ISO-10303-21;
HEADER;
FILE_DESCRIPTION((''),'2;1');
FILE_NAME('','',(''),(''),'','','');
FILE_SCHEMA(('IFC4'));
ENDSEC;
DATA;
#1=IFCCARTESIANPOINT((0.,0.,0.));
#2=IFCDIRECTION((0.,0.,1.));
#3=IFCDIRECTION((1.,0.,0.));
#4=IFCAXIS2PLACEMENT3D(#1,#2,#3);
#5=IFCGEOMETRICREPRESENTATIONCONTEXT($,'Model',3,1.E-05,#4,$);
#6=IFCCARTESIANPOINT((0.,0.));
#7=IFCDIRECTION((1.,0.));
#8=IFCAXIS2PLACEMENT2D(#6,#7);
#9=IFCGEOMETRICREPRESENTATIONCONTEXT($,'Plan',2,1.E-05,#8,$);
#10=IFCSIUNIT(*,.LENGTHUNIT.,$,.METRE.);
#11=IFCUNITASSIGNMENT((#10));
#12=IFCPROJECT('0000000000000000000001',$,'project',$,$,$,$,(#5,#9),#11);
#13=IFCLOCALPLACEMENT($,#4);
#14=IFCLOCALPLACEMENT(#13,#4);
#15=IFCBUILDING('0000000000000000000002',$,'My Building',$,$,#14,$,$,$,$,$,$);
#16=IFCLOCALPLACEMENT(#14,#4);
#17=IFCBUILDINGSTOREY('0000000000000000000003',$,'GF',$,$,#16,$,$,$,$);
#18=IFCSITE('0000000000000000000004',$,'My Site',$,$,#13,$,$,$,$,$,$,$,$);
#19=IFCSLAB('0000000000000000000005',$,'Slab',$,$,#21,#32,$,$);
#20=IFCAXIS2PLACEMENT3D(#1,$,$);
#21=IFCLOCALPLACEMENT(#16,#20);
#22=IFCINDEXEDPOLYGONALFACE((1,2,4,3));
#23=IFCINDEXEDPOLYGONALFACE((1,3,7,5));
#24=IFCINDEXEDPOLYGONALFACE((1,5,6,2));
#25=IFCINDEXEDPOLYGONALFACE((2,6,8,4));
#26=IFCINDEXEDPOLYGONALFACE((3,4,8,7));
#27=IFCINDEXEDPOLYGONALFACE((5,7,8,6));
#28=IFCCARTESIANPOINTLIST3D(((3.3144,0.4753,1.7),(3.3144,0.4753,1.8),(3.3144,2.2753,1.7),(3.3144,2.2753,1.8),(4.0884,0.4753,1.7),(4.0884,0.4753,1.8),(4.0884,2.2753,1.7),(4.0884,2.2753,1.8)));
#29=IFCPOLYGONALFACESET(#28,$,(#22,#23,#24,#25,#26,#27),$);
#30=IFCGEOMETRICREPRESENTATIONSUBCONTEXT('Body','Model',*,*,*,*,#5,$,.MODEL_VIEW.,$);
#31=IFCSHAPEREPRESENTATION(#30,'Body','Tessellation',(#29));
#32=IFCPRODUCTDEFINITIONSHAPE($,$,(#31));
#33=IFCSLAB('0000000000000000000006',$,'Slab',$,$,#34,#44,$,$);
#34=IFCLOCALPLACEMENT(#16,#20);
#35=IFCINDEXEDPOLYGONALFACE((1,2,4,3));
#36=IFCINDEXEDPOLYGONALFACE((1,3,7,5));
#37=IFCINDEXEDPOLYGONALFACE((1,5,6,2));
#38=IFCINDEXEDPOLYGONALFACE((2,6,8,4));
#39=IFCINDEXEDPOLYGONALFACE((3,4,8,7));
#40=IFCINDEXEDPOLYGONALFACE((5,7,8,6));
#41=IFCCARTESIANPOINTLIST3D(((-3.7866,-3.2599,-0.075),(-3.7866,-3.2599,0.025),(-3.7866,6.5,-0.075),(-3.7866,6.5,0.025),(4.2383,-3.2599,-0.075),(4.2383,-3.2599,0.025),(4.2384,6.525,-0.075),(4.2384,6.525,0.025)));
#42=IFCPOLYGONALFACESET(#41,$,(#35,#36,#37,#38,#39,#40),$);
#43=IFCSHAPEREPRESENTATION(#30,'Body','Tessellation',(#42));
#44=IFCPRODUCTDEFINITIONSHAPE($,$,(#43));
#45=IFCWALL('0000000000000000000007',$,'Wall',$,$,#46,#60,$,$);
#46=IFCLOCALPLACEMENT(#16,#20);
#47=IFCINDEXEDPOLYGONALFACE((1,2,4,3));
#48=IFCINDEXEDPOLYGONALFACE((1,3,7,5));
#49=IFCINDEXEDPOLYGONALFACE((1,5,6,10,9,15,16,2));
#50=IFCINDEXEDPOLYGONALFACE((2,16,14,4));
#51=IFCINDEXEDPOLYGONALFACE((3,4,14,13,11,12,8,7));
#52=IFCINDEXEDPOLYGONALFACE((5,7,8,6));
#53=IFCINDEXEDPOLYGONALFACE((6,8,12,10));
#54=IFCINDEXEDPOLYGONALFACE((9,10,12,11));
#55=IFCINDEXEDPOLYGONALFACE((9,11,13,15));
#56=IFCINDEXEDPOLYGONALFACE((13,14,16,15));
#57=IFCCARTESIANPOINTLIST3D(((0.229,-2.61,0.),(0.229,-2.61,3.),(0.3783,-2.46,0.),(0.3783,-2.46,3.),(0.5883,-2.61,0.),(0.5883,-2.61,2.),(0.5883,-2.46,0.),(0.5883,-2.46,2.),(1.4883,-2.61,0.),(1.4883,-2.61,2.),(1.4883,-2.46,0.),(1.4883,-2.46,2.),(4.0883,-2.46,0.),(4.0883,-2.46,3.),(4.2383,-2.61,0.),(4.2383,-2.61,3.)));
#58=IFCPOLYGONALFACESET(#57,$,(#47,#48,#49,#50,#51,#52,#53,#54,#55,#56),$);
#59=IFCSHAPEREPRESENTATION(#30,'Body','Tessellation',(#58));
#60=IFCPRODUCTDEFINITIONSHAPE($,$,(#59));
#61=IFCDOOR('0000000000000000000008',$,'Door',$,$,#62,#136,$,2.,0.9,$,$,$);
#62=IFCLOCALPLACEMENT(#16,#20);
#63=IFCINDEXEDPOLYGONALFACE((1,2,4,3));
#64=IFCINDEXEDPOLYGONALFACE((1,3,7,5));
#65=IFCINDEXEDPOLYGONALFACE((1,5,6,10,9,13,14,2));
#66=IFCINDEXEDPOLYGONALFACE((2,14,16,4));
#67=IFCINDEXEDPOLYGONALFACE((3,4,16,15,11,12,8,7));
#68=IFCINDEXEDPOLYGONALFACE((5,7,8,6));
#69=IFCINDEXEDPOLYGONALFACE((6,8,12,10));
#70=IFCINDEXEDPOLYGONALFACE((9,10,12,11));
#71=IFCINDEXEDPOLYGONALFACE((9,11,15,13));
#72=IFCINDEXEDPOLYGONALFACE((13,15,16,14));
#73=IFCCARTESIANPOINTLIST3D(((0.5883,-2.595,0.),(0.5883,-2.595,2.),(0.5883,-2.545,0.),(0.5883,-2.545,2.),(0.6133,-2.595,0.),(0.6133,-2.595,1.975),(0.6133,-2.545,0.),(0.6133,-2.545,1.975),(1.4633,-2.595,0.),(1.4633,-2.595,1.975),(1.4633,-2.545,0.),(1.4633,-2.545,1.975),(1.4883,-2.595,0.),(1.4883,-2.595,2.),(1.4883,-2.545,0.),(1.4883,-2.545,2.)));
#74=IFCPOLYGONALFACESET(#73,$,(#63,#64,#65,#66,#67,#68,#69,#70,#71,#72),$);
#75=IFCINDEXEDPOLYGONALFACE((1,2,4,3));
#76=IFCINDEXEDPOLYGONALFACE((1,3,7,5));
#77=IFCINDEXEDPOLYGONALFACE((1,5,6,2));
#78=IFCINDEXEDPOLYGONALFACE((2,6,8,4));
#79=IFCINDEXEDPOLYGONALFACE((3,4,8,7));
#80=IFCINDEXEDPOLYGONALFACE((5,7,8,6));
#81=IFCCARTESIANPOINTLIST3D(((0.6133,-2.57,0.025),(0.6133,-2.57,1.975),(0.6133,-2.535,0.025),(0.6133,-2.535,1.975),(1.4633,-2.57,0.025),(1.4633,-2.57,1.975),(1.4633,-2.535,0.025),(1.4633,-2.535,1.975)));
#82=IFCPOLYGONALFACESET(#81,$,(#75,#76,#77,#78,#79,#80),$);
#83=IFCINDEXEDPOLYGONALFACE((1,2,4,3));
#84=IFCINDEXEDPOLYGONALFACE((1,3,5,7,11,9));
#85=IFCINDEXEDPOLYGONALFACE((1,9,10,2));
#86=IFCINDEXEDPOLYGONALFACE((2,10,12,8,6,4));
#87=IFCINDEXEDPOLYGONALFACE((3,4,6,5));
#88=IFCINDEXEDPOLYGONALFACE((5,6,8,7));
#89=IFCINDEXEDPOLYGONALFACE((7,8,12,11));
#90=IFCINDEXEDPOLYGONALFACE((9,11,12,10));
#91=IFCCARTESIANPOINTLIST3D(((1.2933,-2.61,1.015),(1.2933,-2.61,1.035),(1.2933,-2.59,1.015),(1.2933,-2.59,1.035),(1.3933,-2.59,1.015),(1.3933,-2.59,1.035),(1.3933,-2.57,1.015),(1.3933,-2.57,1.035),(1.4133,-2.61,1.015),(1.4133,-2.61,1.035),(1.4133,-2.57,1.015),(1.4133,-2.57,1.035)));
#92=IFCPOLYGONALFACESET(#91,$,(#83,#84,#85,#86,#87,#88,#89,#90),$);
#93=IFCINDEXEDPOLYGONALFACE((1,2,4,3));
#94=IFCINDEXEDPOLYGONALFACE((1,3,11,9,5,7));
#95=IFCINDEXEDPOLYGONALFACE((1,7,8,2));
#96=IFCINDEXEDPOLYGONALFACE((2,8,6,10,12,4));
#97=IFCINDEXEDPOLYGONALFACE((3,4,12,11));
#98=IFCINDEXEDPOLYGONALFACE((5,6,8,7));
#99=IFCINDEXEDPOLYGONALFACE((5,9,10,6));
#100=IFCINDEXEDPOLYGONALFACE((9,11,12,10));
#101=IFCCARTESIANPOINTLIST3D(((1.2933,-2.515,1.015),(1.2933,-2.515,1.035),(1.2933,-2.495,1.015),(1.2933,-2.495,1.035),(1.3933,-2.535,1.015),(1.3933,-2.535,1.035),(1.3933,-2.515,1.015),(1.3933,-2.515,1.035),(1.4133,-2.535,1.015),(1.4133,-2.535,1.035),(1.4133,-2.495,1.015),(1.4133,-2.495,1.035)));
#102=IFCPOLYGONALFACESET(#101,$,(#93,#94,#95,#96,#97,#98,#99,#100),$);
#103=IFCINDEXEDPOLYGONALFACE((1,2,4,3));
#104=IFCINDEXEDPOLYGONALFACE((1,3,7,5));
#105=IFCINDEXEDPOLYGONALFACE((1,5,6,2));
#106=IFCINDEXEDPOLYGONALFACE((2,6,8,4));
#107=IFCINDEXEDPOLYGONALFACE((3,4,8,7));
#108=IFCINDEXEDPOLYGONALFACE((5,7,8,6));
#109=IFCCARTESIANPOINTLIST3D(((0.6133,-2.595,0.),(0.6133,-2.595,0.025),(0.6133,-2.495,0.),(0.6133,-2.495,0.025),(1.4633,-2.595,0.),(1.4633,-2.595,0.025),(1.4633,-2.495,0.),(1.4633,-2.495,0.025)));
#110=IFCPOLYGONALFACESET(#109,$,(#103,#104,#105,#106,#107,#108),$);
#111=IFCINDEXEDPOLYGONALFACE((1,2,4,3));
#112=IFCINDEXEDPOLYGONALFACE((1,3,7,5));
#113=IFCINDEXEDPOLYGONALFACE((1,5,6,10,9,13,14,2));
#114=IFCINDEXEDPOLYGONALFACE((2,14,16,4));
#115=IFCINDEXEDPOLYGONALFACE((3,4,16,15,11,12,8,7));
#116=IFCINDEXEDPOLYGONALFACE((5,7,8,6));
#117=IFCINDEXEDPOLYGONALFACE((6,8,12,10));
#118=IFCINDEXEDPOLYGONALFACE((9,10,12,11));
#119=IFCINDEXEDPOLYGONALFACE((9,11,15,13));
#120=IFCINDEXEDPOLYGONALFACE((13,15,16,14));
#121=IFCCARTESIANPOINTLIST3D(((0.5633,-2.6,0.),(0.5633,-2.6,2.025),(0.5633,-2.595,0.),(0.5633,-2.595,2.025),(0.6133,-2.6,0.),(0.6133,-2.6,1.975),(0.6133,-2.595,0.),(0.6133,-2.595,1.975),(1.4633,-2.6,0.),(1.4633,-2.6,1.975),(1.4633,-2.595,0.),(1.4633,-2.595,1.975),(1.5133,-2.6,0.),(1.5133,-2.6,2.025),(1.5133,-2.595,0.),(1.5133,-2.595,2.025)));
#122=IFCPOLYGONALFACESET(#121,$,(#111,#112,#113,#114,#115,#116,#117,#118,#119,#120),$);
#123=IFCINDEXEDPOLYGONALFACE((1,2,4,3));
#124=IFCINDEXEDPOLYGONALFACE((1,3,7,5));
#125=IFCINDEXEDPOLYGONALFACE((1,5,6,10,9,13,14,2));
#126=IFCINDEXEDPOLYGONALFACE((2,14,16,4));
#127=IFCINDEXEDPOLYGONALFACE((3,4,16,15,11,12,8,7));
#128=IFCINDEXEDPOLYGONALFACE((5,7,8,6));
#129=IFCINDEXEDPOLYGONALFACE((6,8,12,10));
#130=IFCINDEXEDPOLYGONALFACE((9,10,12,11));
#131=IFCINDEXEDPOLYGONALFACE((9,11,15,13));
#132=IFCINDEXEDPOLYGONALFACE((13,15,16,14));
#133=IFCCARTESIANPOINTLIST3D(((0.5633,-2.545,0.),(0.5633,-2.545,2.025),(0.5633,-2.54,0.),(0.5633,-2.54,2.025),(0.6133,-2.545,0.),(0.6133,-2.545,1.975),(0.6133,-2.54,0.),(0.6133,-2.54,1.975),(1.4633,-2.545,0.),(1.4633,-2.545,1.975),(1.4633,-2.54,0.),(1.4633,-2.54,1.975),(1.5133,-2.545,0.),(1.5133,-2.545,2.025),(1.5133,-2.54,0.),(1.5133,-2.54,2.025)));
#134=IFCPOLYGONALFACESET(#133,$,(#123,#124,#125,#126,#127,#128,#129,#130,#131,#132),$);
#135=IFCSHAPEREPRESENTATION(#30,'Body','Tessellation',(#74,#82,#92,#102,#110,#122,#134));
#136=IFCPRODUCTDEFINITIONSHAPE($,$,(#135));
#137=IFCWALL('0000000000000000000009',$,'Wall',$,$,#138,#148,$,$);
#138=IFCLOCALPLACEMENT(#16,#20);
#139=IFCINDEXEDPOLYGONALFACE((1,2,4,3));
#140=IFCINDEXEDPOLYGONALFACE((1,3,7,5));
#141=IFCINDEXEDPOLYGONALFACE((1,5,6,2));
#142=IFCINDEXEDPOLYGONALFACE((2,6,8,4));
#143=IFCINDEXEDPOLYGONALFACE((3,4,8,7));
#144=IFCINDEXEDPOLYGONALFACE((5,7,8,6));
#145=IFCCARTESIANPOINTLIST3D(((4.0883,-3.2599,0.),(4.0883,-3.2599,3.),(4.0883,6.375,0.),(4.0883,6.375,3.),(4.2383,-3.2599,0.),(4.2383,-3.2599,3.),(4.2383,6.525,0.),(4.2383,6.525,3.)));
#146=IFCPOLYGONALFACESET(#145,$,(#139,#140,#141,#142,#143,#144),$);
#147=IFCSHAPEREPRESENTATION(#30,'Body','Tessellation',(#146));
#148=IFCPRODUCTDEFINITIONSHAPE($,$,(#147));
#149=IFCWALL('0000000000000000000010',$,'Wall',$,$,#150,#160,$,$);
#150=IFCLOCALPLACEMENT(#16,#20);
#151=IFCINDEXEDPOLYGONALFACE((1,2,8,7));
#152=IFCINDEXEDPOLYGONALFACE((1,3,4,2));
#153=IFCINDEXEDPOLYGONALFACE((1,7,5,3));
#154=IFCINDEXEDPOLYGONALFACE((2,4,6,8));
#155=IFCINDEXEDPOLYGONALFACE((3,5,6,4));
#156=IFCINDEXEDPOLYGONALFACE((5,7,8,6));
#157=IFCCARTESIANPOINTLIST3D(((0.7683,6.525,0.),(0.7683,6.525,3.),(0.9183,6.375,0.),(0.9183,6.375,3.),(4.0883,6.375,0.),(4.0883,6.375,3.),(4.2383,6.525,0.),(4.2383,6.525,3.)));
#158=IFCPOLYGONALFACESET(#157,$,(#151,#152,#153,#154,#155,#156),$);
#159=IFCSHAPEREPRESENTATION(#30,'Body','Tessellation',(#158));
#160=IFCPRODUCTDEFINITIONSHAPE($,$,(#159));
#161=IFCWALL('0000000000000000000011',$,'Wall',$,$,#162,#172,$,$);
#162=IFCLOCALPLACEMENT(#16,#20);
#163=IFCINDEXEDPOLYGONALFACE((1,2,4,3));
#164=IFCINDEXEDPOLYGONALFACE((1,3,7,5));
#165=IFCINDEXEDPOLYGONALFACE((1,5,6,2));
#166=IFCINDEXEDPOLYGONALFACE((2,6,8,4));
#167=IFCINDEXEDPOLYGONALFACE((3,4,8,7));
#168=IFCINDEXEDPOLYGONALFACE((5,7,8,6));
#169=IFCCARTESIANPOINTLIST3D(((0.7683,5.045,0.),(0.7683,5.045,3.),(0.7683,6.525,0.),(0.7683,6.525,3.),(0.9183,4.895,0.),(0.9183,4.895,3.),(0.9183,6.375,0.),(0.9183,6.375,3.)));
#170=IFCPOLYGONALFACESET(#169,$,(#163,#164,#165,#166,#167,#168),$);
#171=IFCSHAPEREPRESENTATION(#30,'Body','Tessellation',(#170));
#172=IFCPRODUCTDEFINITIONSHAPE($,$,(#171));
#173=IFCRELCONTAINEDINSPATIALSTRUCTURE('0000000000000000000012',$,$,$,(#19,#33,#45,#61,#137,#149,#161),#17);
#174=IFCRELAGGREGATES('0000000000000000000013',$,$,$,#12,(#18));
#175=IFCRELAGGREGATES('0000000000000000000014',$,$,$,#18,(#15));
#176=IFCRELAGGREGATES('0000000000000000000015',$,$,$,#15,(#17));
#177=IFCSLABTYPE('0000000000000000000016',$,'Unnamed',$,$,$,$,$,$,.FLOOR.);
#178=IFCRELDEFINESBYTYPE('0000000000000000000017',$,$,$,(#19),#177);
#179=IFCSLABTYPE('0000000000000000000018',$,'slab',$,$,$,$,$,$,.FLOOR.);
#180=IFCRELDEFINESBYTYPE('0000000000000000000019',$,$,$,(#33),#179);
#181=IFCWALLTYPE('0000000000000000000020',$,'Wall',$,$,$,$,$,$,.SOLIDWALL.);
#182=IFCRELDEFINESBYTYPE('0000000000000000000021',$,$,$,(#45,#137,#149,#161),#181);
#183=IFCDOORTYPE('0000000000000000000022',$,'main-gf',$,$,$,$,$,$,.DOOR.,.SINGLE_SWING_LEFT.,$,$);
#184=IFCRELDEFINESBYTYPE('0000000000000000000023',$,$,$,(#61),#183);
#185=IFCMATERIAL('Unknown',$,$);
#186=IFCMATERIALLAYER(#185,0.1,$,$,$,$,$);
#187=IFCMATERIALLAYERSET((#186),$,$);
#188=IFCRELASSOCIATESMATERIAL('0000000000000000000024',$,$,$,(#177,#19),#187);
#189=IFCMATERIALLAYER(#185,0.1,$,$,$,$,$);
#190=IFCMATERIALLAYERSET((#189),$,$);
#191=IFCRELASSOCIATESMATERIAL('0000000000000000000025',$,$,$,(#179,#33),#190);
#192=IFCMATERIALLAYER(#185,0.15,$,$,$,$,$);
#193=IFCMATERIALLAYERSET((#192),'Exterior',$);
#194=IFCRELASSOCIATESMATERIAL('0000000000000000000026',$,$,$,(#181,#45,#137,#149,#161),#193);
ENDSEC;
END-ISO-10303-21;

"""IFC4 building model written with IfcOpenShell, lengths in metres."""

from ifc_helpers import new_model, entity, si_unit, frame, origin_with_axes, origin_2d_with_axis, place, context, subcontext, project, spatial, line, indexed_curve, outline, extrude, shape, source, transform, mapped, material, layer, layer_set, layer_usage, type_object, type_shapes, element, fill, save


model = new_model("IFC4")

# Units and contexts
model_context = context("Model", 3, precision=1e-05, world=origin_with_axes())
plan_context = context("Plan", 2, precision=1e-05, world=origin_2d_with_axis())
body_context_1 = subcontext(model_context, "Body", "Model", "MODEL_VIEW")
body_context_2 = subcontext(plan_context, "Body", "Plan", "PLAN_VIEW")
ifc_project = project(units=[si_unit("LENGTHUNIT", "METRE")], contexts=[model_context, plan_context])

# Site, building, storey
site_placement = place(None, origin_with_axes())
site = spatial("IfcSite", under=ifc_project, at=site_placement, Name="My Site")
building_placement = place(site_placement, origin_with_axes())
building = spatial("IfcBuilding", under=site, at=building_placement, Name="My Building")
storey_placement = place(building_placement, origin_with_axes())
storey = spatial("IfcBuildingStorey", under=building, at=storey_placement, Name="GF")

# Slabs
ifc_material = material(Name="Unknown")
ifc_layer_1 = layer(ifc_material, 0.1)
ifc_layer_set_1 = layer_set([ifc_layer_1])
ifc_layer_usage_1 = layer_usage(ifc_layer_set_1, "AXIS3", "POSITIVE", -0.1)
slab_type_1 = type_object("IfcSlabType", Name="Unnamed", PredefinedType="FLOOR", material=ifc_layer_set_1)
slab_1_placement = place(storey_placement, frame((3.3144, 0.4753, 1.8), z_axis=(0.0, 0.0, 1.0), x_axis=(1.0, 0.0, 0.0)))
element("IfcSlab", 1, at=slab_1_placement, inside=storey, type_object=slab_type_1, material=ifc_layer_usage_1, Name="Slab", context=body_context_1, shape_type="SweptSolid", body=[
    extrude(outline(indexed_curve([(0.0, 0.0), (0.774, 0.0), (0.774, 1.8), (0.0, 1.8), (0.0, 0.0)])), frame((0.0, 0.0, -0.1), z_axis=(0.0, 0.0, 1.0), x_axis=(1.0, 0.0, 0.0)), (0.0, 0.0, 1.0), 0.1),
])
ifc_layer_2 = layer(ifc_material, 0.1)
ifc_layer_set_2 = layer_set([ifc_layer_2])
ifc_layer_usage_2 = layer_usage(ifc_layer_set_2, "AXIS3", "POSITIVE", -0.1)
slab_type_2 = type_object("IfcSlabType", Name="slab", PredefinedType="FLOOR", material=ifc_layer_set_2)
slab_2_placement = place(storey_placement, frame((4.2384, 6.525, 0.025), z_axis=(0.0, 0.0, 1.0), x_axis=(1.0, 0.0, 0.0)))
element("IfcSlab", 2, at=slab_2_placement, inside=storey, type_object=slab_type_2, material=ifc_layer_usage_2, Name="Slab", context=body_context_1, shape_type="SweptSolid", body=[
    extrude(outline(indexed_curve([(0.0, 0.0), (0.0, -9.7849), (-8.025, -9.7849), (-8.025, -0.025), (0.0, 0.0)])), frame((0.0, 0.0, -0.1), z_axis=(0.0, 0.0, 1.0), x_axis=(1.0, 0.0, 0.0)), (0.0, 0.0, 1.0), 0.1),
])

# Wall, opening, door
ifc_layer_3 = layer(ifc_material, 0.15)
ifc_layer_set_3 = layer_set([ifc_layer_3], Name="Exterior")
ifc_layer_usage_3 = layer_usage(ifc_layer_set_3, "AXIS2", "POSITIVE", 0.0)
wall_type_1 = type_object("IfcWallType", Name="Wall", PredefinedType="SOLIDWALL", material=ifc_layer_set_3)
wall_1_placement = place(storey_placement, frame((0.229, -2.61, 0.0), z_axis=(0.0, 0.0, 1.0), x_axis=(1.0, 0.0, 0.0)))
wall_1 = element("IfcWall", 3, at=wall_1_placement, inside=storey, type_object=wall_type_1, material=ifc_layer_usage_3, Name="Wall", context=body_context_1, shape_type="SweptSolid", body=[
    extrude(outline(indexed_curve([(0.0, 0.0), (0.1494, 0.15), (3.8594, 0.15), (4.0094, 0.0)], segments=[line(1, 2, 3, 4, 1)])), origin_with_axes(), (0.0, 0.0, 1.0), 3.0),
])
shared_shape_1 = source(origin_with_axes(), body_context_1, "Body", "SweptSolid", [
    extrude(outline(indexed_curve([(0.0, 0.0), (0.9, 0.0), (0.9, 2.0), (0.0, 2.0)], segments=[line(1, 2, 3, 4, 1)])), frame((0.0, -0.6, 0.0), z_axis=(0.0, -1.0, 0.0), x_axis=(1.0, 0.0, 0.0)), (0.0, 0.0, -1.0), 1.2),
])
opening_1_placement = place(wall_1_placement, frame((0.3593, 0.015, 0.0), z_axis=(0.0, 0.0, 1.0), x_axis=(1.0, -0.000001, 0.0)))
opening_1 = element("IfcOpeningElement", 4, at=opening_1_placement, cuts=wall_1, PredefinedType="OPENING", context=body_context_1, shape_type="MappedRepresentation", body=[
    mapped(shared_shape_1, transform((0.0, 0.0, 0.0), x_axis=(1.0, 0.0, 0.0), y_axis=(0.0, 1.0, 0.0), z_axis=(0.0, 0.0, 1.0), scale=1.0)),
])
door_type = type_object("IfcDoorType", Name="main-gf", OperationType="SINGLE_SWING_LEFT", PredefinedType="DOOR")
shared_shape_2 = source(origin_with_axes(), body_context_1, "Body", "SweptSolid", [
    extrude(outline(indexed_curve([(0.0, 0.0), (0.0, 2.0), (0.9, 2.0), (0.9, 0.0), (0.875, 0.0), (0.875, 1.975), (0.025, 1.975), (0.025, 0.0)], segments=[line(1, 2, 3, 4, 5, 6, 7, 8, 1)])), frame((0.0, 0.0, 0.0), z_axis=(0.0, -1.0, 0.0), x_axis=(1.0, 0.0, 0.0)), (0.0, 0.0, -1.0), 0.05),
    extrude(outline(indexed_curve([(0.0, 0.0), (0.85, 0.0), (0.85, 0.035), (0.0, 0.035)], segments=[line(1, 2, 3, 4, 1)])), frame((0.025, 0.025, 0.025), z_axis=(0.0, 0.0, 1.0), x_axis=(1.0, 0.0, 0.0)), (0.0, 0.0, 1.0), 1.95),
    extrude(outline(indexed_curve([(0.0, 0.0), (0.0, -0.04), (-0.12, -0.04), (-0.12, -0.02), (-0.02, -0.02), (-0.02, 0.0)], segments=[line(1, 2, 3, 4, 5, 6, 1)])), frame((0.825, 0.025, 1.015), z_axis=(0.0, 0.0, 1.0), x_axis=(1.0, 0.0, 0.0)), (0.0, 0.0, 1.0), 0.02),
    extrude(outline(indexed_curve([(0.0, 0.0), (0.0, 0.04), (-0.12, 0.04), (-0.12, 0.02), (-0.02, 0.02), (-0.02, 0.0)], segments=[line(1, 2, 3, 4, 5, 6, 1)])), frame((0.825, 0.06, 1.015), z_axis=(0.0, 0.0, 1.0), x_axis=(1.0, 0.0, 0.0)), (0.0, 0.0, 1.0), 0.02),
    extrude(outline(indexed_curve([(0.0, 0.0), (0.85, 0.0), (0.85, 0.1), (0.0, 0.1)], segments=[line(1, 2, 3, 4, 1)])), frame((0.025, 0.0, 0.0), z_axis=(0.0, 0.0, 1.0), x_axis=(1.0, 0.0, 0.0)), (0.0, 0.0, 1.0), 0.025),
    extrude(outline(indexed_curve([(0.0, 0.0), (0.0, 2.025), (0.95, 2.025), (0.95, 0.0), (0.9, 0.0), (0.9, 1.975), (0.05, 1.975), (0.05, 0.0)], segments=[line(1, 2, 3, 4, 5, 6, 7, 8, 1)])), frame((-0.025, -0.005, 0.0), z_axis=(0.0, -1.0, 0.0), x_axis=(1.0, 0.0, 0.0)), (0.0, 0.0, -1.0), 0.005),
    extrude(outline(indexed_curve([(0.0, 0.0), (0.0, 2.025), (0.95, 2.025), (0.95, 0.0), (0.9, 0.0), (0.9, 1.975), (0.05, 1.975), (0.05, 0.0)], segments=[line(1, 2, 3, 4, 5, 6, 7, 8, 1)])), frame((-0.025, 0.05, 0.0), z_axis=(0.0, -1.0, 0.0), x_axis=(1.0, 0.0, 0.0)), (0.0, 0.0, -1.0), 0.005),
])
shared_shape_3 = source(origin_with_axes(), body_context_2, "Body", "Curve2D", [
    entity("IfcIndexedPolyCurve", entity("IfcCartesianPointList2D", [[0.0, 0.0], [0.025, 0.0], [0.025, 0.05], [0.0, 0.05]]), [entity("IfcLineIndex", [1, 2, 3, 4, 1])]),
    entity("IfcIndexedPolyCurve", entity("IfcCartesianPointList2D", [[0.9, 0.0], [0.875, 0.0], [0.875, 0.05], [0.9, 0.05]]), [entity("IfcLineIndex", [1, 2, 3, 4, 1])]),
    entity("IfcIndexedPolyCurve", entity("IfcCartesianPointList2D", [[0.025, 0.05], [0.025, -0.8], [0.06, -0.8]])),
    entity("IfcTrimmedCurve", entity("IfcEllipse", entity("IfcAxis2Placement2D", entity("IfcCartesianPoint", [0.06, 0.05]), entity("IfcDirection", [1.0, 0.0])), 0.815, 0.85), [entity("IfcCartesianPoint", [0.06, -0.8])], [entity("IfcCartesianPoint", [0.06, 0.9])], True, "CARTESIAN"),
    entity("IfcIndexedPolyCurve", entity("IfcCartesianPointList2D", [[0.025, 0.05], [0.06, 0.05], [0.06, 0.9], [0.025, 0.9]]), [entity("IfcLineIndex", [1, 2, 3, 4, 1])]),
])
type_shapes(door_type, [shared_shape_2, shared_shape_3])
door_1_placement = place(opening_1_placement, origin_with_axes())
door_1 = element("IfcDoor", 5, at=door_1_placement, inside=storey, type_object=door_type, Name="Door", OverallHeight=2.0, OverallWidth=0.9, shapes=[
    shape(body_context_1, "Body", "MappedRepresentation", [mapped(shared_shape_2, transform((0.0, 0.0, 0.0), x_axis=(1.0, 0.0, 0.0), y_axis=(0.0, 1.0, 0.0), z_axis=(0.0, 0.0, 1.0), scale=1.0))]),
    shape(body_context_2, "Body", "MappedRepresentation", [mapped(shared_shape_3, transform((0.0, 0.0, 0.0), x_axis=(1.0, 0.0, 0.0), y_axis=(0.0, 1.0, 0.0), z_axis=(0.0, 0.0, 1.0), scale=1.0))]),
])
fill(opening_1, door_1)

# Walls
ifc_layer_usage_4 = layer_usage(ifc_layer_set_3, "AXIS2", "POSITIVE", 0.0)
wall_2_placement = place(storey_placement, frame((4.2383, -3.2599, 0.0), z_axis=(0.0, 0.0, 1.0), x_axis=(0.0, 1.0, 0.0)))
element("IfcWall", 6, at=wall_2_placement, inside=storey, type_object=wall_type_1, material=ifc_layer_usage_4, Name="Wall", context=body_context_1, shape_type="SweptSolid", body=[
    extrude(outline(indexed_curve([(0.0, 0.0), (0.0, 0.15), (9.6349, 0.15), (9.7849, 0.0)], segments=[line(1, 2, 3, 4, 1)])), origin_with_axes(), (0.0, 0.0, 1.0), 3.0),
])
ifc_layer_usage_5 = layer_usage(ifc_layer_set_3, "AXIS2", "POSITIVE", 0.0)
wall_3_placement = place(storey_placement, frame((4.2383, 6.525, 0.0), z_axis=(0.0, 0.0, 1.0), x_axis=(-1.0, 0.0, 0.0)))
element("IfcWall", 7, at=wall_3_placement, inside=storey, type_object=wall_type_1, material=ifc_layer_usage_5, Name="Wall", context=body_context_1, shape_type="SweptSolid", body=[
    extrude(outline(indexed_curve([(0.0, 0.0), (0.15, 0.15), (3.32, 0.15), (3.47, 0.0)], segments=[line(1, 2, 3, 4, 1)])), origin_with_axes(), (0.0, 0.0, 1.0), 3.0),
])
ifc_layer_usage_6 = layer_usage(ifc_layer_set_3, "AXIS2", "POSITIVE", 0.0)
wall_4_placement = place(storey_placement, frame((0.7683, 6.525, 0.0), z_axis=(0.0, 0.0, 1.0), x_axis=(0.0, -1.0, 0.0)))
element("IfcWall", 8, at=wall_4_placement, inside=storey, type_object=wall_type_1, material=ifc_layer_usage_6, Name="Wall", context=body_context_1, shape_type="SweptSolid", body=[
    extrude(outline(indexed_curve([(0.0, 0.0), (0.15, 0.15), (1.63, 0.15), (1.48, 0.0)], segments=[line(1, 2, 3, 4, 1)])), origin_with_axes(), (0.0, 0.0, 1.0), 3.0),
])

save(model, "model.ifc")
